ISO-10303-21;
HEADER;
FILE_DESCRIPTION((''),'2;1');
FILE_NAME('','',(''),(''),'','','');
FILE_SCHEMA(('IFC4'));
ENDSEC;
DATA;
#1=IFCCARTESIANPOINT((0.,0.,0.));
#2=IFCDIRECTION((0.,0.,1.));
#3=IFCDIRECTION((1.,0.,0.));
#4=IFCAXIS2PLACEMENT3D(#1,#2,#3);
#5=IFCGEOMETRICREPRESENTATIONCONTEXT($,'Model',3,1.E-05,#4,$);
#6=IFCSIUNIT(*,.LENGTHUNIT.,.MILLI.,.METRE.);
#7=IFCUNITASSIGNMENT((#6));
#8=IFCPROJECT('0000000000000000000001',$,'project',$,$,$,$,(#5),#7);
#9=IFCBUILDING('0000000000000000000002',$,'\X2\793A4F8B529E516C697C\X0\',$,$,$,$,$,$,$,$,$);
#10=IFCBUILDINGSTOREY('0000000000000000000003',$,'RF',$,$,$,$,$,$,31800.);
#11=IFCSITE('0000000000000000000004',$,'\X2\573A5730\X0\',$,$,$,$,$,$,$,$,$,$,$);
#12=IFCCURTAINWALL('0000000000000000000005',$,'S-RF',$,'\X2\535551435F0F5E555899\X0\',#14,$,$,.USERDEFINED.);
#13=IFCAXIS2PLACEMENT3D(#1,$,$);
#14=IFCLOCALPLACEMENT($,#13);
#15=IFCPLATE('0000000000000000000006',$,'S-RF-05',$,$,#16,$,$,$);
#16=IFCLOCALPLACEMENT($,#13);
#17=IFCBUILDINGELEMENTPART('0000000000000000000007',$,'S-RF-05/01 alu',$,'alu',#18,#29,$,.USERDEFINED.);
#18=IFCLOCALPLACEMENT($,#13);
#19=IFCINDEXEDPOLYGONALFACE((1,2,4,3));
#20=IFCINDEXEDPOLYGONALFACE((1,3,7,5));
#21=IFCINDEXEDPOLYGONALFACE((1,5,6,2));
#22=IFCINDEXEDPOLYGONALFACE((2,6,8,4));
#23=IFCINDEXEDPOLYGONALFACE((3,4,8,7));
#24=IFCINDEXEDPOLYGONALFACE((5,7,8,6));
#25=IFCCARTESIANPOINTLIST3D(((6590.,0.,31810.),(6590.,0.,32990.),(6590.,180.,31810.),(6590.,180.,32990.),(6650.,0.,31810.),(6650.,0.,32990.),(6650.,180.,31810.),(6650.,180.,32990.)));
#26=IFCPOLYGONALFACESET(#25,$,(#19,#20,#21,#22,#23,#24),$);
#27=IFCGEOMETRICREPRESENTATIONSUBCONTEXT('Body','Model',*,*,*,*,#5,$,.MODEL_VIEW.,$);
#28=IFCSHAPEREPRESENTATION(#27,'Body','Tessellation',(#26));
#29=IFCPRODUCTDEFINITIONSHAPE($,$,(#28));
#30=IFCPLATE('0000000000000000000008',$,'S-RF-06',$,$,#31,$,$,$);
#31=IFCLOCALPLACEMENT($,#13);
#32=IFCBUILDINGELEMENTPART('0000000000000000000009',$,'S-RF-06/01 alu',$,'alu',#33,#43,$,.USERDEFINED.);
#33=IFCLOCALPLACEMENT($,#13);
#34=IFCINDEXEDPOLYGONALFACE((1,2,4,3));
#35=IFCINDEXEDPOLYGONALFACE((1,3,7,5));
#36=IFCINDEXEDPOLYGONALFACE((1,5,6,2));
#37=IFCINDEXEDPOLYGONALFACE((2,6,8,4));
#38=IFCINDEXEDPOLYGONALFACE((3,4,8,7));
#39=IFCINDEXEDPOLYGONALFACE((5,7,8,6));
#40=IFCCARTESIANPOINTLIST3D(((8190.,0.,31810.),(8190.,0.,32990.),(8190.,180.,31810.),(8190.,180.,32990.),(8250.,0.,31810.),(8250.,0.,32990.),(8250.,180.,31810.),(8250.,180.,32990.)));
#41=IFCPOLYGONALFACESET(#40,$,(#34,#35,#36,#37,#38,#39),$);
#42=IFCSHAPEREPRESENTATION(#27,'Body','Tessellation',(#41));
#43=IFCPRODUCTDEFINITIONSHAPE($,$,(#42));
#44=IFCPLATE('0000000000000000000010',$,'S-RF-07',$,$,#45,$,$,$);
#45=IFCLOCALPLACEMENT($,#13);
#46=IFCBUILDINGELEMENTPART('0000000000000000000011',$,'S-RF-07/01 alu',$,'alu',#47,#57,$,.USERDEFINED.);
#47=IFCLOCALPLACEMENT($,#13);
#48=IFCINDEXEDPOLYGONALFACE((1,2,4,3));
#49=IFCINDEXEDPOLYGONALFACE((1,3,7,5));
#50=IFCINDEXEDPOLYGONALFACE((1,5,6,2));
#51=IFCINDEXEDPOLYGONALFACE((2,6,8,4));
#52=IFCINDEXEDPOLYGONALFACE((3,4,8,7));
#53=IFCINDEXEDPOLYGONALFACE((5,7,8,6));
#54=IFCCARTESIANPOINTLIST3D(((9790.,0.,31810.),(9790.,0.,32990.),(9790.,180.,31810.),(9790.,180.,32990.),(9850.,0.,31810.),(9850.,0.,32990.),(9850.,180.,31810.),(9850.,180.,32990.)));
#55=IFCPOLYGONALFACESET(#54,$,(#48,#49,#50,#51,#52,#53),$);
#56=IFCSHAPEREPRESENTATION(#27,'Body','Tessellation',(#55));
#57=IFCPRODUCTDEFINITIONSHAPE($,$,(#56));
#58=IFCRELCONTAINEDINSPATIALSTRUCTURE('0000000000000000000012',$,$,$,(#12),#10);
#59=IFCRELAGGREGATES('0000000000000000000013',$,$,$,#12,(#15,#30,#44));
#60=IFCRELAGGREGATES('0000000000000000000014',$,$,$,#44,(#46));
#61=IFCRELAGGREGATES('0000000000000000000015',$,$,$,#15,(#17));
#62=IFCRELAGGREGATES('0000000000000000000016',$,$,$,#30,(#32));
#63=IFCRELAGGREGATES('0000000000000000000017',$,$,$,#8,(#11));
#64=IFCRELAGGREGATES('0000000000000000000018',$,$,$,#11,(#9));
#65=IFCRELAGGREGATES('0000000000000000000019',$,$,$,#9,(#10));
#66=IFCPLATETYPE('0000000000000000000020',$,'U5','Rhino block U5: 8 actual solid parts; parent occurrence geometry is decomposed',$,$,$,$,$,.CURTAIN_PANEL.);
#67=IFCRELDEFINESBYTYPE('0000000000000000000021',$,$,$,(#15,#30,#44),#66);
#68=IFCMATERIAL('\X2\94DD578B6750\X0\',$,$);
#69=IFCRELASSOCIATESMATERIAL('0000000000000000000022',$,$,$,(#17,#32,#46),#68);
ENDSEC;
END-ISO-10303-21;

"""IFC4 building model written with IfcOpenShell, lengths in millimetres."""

from ifc_helpers import new_model, si_unit, frame, frame_2d, origin, origin_with_axes, place, context, subcontext, project, spatial, rectangle, extrude, source, transform, mapped, material, type_object, element, aggregate, save


model = new_model("IFC4")

# Units and contexts
model_context = context("Model", 3, precision=1e-05, world=origin_with_axes())
body_context = subcontext(model_context, "Body", "Model", "MODEL_VIEW")
ifc_project = project(units=[si_unit("LENGTHUNIT", "METRE", prefix="MILLI")], contexts=[model_context])

# Site, building, storey
site = spatial("IfcSite", under=ifc_project, Name="场地")
building = spatial("IfcBuilding", under=site, Name="示例办公楼")
storey = spatial("IfcBuildingStorey", under=building, Name="RF", Elevation=31800.0)

# Curtain wall, plates, building element parts
curtain_wall = element("IfcCurtainWall", 1, inside=storey, Name="S-RF", ObjectType="单元式幕墙", PredefinedType="USERDEFINED")
plate_type = type_object("IfcPlateType", Name="U5", Description="Rhino block U5: 8 actual solid parts; parent occurrence geometry is decomposed", PredefinedType="CURTAIN_PANEL")
plate_1_placement = place(None, frame((6590.0, 0.0, 31810.0), z_axis=(0.0, 0.0, 1.0), x_axis=(1.0, 0.0, 0.0)))
plate_1 = element("IfcPlate", 2, at=plate_1_placement, type_object=plate_type, Name="S-RF-05")
ifc_material_1 = material(Name="铝型材")
shared_shape_1 = source(origin(), body_context, "Body", "SweptSolid", [
    extrude(rectangle(XDim=60.0, YDim=180.0, at=frame_2d((30.0, 90.0))), origin(), (0.0, 0.0, 1.0), 1180.0),
])
building_element_part_1_placement = place(plate_1_placement, origin())
building_element_part_1 = element("IfcBuildingElementPart", 3, at=building_element_part_1_placement, material=ifc_material_1, Name="S-RF-05/01 alu", ObjectType="alu", PredefinedType="USERDEFINED", context=body_context, shape_type="MappedRepresentation", body=[
    mapped(shared_shape_1, transform((0.0, 0.0, 0.0))),
])
plate_2_placement = place(None, frame((8190.0, 0.0, 31810.0), z_axis=(0.0, 0.0, 1.0), x_axis=(1.0, 0.0, 0.0)))
plate_2 = element("IfcPlate", 4, at=plate_2_placement, type_object=plate_type, Name="S-RF-06")
building_element_part_2_placement = place(plate_2_placement, origin())
building_element_part_2 = element("IfcBuildingElementPart", 5, at=building_element_part_2_placement, material=ifc_material_1, Name="S-RF-06/01 alu", ObjectType="alu", PredefinedType="USERDEFINED", context=body_context, shape_type="MappedRepresentation", body=[
    mapped(shared_shape_1, transform((0.0, 0.0, 0.0))),
])
plate_3_placement = place(None, frame((9790.0, 0.0, 31810.0), z_axis=(0.0, 0.0, 1.0), x_axis=(1.0, 0.0, 0.0)))
plate_3 = element("IfcPlate", 6, at=plate_3_placement, type_object=plate_type, Name="S-RF-07")
aggregate(curtain_wall, [plate_1, plate_2, plate_3])
building_element_part_3_placement = place(plate_3_placement, origin())
building_element_part_3 = element("IfcBuildingElementPart", 7, at=building_element_part_3_placement, material=ifc_material_1, Name="S-RF-07/01 alu", ObjectType="alu", PredefinedType="USERDEFINED", context=body_context, shape_type="MappedRepresentation", body=[
    mapped(shared_shape_1, transform((0.0, 0.0, 0.0))),
])
aggregate(plate_3, [building_element_part_3])
aggregate(plate_1, [building_element_part_1])
aggregate(plate_2, [building_element_part_2])

save(model, "model.ifc")
